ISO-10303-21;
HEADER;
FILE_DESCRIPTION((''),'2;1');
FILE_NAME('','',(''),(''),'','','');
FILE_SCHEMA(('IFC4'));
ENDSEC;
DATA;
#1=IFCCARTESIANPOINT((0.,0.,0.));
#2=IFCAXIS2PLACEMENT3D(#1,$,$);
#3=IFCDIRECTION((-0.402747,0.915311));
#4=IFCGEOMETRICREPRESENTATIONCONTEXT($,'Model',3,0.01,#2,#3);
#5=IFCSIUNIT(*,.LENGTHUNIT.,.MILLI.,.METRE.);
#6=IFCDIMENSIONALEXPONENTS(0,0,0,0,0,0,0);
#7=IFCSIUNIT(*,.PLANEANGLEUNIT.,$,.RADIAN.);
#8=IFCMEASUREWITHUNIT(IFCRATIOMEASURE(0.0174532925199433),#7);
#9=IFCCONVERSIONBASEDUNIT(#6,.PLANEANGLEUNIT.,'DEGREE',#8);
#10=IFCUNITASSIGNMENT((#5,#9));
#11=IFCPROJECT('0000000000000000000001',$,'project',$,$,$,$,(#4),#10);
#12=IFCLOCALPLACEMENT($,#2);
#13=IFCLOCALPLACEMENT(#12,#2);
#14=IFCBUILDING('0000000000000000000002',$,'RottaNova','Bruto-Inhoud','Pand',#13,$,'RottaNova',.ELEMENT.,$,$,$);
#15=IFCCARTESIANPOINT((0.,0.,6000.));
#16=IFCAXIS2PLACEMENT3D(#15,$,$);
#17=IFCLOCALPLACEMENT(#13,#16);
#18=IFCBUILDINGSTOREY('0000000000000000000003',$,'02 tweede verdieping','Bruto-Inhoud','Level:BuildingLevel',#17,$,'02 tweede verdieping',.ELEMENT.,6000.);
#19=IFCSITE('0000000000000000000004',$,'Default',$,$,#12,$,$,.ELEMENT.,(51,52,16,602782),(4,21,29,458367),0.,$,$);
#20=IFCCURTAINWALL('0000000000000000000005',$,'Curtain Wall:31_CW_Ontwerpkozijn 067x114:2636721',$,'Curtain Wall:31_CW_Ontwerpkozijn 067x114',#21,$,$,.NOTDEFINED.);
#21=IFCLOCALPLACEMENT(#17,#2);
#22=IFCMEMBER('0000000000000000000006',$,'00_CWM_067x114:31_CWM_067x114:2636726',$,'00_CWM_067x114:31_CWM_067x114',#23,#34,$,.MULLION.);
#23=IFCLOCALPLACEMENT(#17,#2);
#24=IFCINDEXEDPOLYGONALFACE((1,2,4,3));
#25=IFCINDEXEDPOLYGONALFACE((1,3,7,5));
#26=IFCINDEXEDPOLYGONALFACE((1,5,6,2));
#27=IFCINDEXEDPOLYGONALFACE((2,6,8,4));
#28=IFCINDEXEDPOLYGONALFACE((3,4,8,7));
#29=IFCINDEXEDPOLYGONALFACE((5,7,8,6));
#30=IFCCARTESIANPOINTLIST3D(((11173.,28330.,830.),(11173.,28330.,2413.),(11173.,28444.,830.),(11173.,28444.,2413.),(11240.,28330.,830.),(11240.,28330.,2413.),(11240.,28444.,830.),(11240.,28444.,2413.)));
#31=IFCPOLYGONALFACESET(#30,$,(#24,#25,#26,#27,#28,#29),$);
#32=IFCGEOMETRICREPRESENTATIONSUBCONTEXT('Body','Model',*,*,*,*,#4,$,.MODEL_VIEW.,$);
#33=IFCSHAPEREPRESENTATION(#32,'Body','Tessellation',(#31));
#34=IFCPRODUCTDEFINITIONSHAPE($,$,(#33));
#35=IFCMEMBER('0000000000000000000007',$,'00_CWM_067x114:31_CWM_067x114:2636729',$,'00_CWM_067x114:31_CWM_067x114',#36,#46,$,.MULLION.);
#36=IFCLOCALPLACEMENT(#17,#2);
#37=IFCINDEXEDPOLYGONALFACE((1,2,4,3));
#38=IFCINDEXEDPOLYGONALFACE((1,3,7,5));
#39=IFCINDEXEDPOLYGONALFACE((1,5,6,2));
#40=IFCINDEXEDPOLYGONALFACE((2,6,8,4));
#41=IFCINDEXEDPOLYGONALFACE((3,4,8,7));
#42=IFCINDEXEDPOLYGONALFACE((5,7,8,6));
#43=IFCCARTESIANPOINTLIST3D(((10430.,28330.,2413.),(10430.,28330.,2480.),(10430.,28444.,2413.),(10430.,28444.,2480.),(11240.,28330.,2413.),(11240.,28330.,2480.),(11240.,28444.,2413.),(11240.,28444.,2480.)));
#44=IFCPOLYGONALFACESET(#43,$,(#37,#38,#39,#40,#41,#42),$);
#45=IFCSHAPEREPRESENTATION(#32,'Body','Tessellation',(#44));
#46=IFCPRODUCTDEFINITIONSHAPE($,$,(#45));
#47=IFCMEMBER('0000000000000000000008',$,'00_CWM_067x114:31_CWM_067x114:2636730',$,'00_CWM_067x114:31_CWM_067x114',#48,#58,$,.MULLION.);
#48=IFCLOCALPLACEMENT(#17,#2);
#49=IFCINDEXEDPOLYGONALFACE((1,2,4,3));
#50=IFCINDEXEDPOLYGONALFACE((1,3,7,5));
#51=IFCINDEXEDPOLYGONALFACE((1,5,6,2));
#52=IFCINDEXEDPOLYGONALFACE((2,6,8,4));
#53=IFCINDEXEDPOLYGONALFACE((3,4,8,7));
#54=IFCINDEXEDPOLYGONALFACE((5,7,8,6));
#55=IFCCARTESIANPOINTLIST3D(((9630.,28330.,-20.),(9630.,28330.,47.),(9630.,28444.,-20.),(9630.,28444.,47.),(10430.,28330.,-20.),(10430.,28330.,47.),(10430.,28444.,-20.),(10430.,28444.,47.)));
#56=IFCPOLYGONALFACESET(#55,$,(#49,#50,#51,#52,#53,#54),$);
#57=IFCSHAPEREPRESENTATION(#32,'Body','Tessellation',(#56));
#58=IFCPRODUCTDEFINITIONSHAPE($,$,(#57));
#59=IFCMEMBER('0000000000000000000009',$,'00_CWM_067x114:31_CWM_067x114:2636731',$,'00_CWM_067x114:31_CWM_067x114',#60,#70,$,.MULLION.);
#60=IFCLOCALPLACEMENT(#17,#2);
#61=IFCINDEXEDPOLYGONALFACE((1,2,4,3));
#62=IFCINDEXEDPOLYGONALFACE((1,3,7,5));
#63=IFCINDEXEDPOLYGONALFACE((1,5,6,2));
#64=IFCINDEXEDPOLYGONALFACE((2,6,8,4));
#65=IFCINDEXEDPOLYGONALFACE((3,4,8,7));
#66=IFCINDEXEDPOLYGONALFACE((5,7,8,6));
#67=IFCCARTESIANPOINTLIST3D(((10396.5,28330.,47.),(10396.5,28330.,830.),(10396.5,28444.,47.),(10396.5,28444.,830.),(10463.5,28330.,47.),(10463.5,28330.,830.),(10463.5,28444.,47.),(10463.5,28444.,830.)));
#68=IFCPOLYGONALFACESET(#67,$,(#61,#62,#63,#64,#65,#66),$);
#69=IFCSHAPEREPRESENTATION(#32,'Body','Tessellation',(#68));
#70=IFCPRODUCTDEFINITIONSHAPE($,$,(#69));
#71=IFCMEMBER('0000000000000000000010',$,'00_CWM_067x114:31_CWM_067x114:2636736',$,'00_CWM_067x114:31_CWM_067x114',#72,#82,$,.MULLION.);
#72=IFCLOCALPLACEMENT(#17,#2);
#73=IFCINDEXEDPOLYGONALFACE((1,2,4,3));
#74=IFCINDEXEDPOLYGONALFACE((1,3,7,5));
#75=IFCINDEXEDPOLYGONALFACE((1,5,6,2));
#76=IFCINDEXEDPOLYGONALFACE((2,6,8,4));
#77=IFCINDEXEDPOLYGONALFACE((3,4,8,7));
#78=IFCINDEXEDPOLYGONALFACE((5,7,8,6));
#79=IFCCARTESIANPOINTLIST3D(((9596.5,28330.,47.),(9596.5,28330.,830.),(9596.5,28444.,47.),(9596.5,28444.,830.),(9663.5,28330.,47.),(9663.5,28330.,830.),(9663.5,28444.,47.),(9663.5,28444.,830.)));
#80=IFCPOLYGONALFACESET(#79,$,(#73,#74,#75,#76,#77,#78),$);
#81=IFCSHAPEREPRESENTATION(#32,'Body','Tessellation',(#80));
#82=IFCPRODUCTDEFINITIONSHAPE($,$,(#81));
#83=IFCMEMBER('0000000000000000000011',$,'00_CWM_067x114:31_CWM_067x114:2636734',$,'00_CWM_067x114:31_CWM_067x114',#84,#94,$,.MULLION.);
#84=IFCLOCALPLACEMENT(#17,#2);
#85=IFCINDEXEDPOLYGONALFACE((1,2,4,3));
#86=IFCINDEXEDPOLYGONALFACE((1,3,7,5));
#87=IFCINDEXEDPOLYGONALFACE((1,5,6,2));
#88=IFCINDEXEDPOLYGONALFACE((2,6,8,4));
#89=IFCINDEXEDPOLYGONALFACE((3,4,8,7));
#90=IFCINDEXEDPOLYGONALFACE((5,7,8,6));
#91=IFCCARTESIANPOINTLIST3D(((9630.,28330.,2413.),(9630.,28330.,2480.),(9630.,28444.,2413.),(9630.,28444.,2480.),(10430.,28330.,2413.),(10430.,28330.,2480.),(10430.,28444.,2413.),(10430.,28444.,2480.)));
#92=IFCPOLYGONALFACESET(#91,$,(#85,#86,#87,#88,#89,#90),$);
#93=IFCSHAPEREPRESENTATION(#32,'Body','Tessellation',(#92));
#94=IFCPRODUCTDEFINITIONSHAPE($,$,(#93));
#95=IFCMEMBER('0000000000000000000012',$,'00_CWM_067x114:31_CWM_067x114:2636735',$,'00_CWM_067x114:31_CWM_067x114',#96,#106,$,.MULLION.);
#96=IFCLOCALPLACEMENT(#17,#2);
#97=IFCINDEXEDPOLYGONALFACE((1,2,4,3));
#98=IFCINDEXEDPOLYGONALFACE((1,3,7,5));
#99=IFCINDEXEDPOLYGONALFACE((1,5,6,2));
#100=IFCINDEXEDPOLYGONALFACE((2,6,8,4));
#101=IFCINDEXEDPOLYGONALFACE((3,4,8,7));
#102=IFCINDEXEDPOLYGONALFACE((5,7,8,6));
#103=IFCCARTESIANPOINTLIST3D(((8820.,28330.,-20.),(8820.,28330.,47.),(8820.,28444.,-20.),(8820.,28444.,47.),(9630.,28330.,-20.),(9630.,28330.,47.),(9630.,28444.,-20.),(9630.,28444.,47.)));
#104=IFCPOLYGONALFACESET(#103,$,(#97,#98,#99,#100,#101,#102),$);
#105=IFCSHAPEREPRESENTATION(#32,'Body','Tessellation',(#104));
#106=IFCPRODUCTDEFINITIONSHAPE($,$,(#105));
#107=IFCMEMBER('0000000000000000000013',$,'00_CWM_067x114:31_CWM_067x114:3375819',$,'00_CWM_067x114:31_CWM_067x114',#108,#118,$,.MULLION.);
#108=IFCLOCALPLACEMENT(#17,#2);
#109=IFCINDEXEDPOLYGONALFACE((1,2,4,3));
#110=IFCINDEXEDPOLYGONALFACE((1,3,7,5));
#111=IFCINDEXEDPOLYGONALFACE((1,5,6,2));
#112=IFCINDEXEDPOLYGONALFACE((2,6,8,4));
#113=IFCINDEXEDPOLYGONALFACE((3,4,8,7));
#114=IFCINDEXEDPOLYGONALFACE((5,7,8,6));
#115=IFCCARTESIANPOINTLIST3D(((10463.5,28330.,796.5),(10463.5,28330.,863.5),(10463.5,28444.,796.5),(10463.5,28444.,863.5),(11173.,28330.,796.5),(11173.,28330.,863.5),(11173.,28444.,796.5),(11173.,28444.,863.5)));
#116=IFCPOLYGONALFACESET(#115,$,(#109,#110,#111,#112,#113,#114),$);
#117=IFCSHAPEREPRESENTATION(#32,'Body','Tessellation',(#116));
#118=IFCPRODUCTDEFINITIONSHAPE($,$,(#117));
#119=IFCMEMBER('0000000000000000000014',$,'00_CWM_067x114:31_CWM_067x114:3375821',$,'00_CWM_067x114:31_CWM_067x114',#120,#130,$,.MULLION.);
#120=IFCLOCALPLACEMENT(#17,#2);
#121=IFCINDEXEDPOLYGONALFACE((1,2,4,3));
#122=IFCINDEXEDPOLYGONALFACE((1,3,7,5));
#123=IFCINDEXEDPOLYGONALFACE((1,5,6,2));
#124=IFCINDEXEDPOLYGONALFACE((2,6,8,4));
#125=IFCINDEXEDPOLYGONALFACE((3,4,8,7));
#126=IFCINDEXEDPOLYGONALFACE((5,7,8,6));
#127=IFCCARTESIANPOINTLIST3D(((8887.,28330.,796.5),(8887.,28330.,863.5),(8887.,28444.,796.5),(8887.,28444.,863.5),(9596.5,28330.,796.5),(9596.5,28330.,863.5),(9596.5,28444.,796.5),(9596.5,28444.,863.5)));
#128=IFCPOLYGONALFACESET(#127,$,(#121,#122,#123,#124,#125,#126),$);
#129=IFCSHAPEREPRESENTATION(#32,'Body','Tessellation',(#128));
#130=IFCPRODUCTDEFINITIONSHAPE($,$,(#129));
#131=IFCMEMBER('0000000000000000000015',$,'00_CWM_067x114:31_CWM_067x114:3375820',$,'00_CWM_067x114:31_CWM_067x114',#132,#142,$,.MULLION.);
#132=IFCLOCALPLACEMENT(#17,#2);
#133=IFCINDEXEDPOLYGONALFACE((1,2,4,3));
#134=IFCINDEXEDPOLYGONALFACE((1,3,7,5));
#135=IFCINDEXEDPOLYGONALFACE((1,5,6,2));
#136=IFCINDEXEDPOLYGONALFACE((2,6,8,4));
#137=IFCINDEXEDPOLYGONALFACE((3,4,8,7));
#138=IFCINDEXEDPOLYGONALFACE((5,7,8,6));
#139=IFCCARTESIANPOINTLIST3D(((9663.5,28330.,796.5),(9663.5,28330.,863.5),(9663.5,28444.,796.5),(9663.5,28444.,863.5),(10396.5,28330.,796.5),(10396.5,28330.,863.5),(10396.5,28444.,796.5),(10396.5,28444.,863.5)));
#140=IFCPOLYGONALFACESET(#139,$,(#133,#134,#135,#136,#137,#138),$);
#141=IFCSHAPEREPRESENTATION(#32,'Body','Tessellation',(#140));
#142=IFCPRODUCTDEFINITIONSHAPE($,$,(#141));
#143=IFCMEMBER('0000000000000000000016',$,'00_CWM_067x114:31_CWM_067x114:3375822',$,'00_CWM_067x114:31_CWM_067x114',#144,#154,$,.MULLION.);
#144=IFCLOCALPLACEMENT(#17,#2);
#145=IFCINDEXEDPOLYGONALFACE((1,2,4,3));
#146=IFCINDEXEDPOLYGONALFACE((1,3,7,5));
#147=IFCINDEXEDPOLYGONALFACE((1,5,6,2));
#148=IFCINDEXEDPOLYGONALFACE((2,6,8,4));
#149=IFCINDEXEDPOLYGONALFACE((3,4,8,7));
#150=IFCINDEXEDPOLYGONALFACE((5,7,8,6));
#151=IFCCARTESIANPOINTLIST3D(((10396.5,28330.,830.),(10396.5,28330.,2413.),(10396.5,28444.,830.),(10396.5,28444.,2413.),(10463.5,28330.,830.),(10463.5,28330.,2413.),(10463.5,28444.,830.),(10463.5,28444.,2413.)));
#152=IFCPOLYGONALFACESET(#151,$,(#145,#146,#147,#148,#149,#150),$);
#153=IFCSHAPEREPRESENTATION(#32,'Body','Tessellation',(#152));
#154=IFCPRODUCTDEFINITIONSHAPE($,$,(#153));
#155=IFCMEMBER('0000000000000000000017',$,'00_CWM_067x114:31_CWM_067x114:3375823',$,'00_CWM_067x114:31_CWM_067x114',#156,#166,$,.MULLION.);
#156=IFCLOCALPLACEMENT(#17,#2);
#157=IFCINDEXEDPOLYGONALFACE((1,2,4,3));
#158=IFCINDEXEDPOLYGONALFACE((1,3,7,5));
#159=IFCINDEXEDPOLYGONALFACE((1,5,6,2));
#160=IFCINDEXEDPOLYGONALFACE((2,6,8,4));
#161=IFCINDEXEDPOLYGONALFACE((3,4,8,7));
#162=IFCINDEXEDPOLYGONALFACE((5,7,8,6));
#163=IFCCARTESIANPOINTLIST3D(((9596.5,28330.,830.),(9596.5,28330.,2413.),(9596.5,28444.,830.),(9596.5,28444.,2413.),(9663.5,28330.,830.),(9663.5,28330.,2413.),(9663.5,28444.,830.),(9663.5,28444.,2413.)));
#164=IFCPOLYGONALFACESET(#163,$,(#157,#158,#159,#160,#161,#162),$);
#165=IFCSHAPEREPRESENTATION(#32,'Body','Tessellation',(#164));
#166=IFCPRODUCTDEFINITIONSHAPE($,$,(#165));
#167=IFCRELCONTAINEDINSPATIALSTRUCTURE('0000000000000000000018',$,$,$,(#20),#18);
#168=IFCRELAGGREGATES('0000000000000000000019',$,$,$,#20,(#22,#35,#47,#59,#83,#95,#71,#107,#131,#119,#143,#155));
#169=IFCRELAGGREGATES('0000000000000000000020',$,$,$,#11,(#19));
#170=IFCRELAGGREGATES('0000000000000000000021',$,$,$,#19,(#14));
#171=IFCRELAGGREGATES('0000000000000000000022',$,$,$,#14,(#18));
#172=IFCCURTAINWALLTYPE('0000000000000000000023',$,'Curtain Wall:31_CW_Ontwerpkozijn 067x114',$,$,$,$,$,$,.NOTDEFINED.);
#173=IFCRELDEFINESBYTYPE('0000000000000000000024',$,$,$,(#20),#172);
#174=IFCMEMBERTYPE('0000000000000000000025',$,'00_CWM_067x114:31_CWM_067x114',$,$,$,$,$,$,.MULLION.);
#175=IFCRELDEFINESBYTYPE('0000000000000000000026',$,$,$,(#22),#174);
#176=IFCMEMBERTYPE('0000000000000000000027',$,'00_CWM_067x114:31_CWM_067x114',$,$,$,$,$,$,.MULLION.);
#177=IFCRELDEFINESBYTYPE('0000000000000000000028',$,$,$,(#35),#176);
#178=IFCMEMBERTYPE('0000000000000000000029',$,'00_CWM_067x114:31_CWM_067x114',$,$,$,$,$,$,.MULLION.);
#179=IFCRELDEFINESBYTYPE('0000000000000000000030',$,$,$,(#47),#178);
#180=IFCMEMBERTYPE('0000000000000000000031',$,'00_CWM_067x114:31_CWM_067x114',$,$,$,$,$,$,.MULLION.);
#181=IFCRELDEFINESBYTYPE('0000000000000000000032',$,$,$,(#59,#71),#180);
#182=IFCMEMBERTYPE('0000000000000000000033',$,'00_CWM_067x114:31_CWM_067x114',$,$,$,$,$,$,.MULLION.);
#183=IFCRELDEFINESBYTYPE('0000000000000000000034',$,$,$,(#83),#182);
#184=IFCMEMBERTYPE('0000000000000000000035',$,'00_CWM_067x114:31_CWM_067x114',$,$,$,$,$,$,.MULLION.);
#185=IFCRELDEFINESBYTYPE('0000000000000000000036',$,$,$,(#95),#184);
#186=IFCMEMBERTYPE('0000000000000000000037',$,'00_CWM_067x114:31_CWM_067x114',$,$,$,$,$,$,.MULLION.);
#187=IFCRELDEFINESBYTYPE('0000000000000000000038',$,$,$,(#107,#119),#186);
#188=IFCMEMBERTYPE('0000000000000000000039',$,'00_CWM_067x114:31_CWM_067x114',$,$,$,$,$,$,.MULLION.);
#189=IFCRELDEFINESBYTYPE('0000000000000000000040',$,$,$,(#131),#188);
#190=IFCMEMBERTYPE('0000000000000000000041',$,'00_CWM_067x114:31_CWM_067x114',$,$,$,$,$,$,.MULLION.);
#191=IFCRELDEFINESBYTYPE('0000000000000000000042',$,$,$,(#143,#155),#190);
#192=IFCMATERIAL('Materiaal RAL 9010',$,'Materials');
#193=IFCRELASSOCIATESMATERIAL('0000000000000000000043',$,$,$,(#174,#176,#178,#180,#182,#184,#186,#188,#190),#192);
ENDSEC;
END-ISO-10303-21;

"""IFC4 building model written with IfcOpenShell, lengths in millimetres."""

from ifc_helpers import new_model, entity, si_unit, converted_unit, direction, frame, origin, origin_2d_with_axis, place, context, subcontext, project, spatial, rectangle, extrude, source, transform, mapped, material, material_profile, profile_set, type_object, type_shapes, element, aggregate, save


model = new_model("IFC4")

# Units and contexts
model_context = context("Model", 3, precision=0.01, world=origin(), true_north=direction((-0.402747, 0.915311)))
body_context = subcontext(model_context, "Body", "Model", "MODEL_VIEW")
ifc_project = project(units=[si_unit("LENGTHUNIT", "METRE", prefix="MILLI"), converted_unit("PLANEANGLEUNIT", "DEGREE", entity("IfcRatioMeasure", 0.0174532925199433), si_unit("PLANEANGLEUNIT", "RADIAN"), dimensions=[0, 0, 0, 0, 0, 0, 0])], contexts=[model_context])

# Site, building, storey
site_placement = place(None, origin())
site = spatial("IfcSite", under=ifc_project, at=site_placement, Name="Default", CompositionType="ELEMENT", RefLatitude=(51, 52, 16, 602782), RefLongitude=(4, 21, 29, 458367), RefElevation=0.0)
building_placement = place(site_placement, origin())
building = spatial("IfcBuilding", under=site, at=building_placement, Name="RottaNova", Description="Bruto-Inhoud", ObjectType="Pand", LongName="RottaNova", CompositionType="ELEMENT")
storey_placement = place(building_placement, frame((0.0, 0.0, 6000.0)))
storey = spatial("IfcBuildingStorey", under=building, at=storey_placement, Name="02 tweede verdieping", Description="Bruto-Inhoud", ObjectType="Level:BuildingLevel", LongName="02 tweede verdieping", CompositionType="ELEMENT", Elevation=6000.0)

# Curtain wall, members
curtain_wall_type = type_object("IfcCurtainWallType", Name="Curtain Wall:31_CW_Ontwerpkozijn 067x114", PredefinedType="NOTDEFINED")
curtain_wall_placement = place(storey_placement, frame((0.0, 0.0, -6000.0)))
curtain_wall = element("IfcCurtainWall", 1, at=curtain_wall_placement, inside=storey, type_object=curtain_wall_type, Name="Curtain Wall:31_CW_Ontwerpkozijn 067x114:2636721", ObjectType="Curtain Wall:31_CW_Ontwerpkozijn 067x114", PredefinedType="NOTDEFINED")
ifc_material_1 = material(Name="Materiaal RAL 9010", Category="Materials")
ifc_material_profile = material_profile(ifc_material_1, rectangle(XDim=114.0, YDim=67.0, at=origin_2d_with_axis()), Name="31_CWM_067x114")
ifc_profile_set = profile_set([ifc_material_profile], Name="31_CWM_067x114")
member_type_1 = type_object("IfcMemberType", Name="00_CWM_067x114:31_CWM_067x114", PredefinedType="MULLION", material=ifc_profile_set)
shared_shape_1 = source(origin(), body_context, "Body", "SweptSolid", [
    extrude(rectangle(XDim=114.0, YDim=67.0, at=origin_2d_with_axis()), frame((-33.5, 57.0, -1583.0), z_axis=(0.0, 0.0, 1.0), x_axis=(0.0, -1.0, 0.0)), (0.0, 0.0, 1.0), 1583.0),
])
type_shapes(member_type_1, [shared_shape_1])
member_1_placement = place(curtain_wall_placement, frame((11240.0, 28330.0, 8413.0)))
member_1 = element("IfcMember", 2, at=member_1_placement, type_object=member_type_1, Name="00_CWM_067x114:31_CWM_067x114:2636726", ObjectType="00_CWM_067x114:31_CWM_067x114", PredefinedType="MULLION", context=body_context, shape_type="MappedRepresentation", body=[
    mapped(shared_shape_1, transform((0.0, 0.0, 0.0), scale=1.0)),
])
member_type_2 = type_object("IfcMemberType", Name="00_CWM_067x114:31_CWM_067x114", PredefinedType="MULLION", material=ifc_profile_set)
shared_shape_2 = source(origin(), body_context, "Body", "SweptSolid", [
    extrude(rectangle(XDim=114.0, YDim=67.0, at=origin_2d_with_axis()), frame((-33.5, 57.0, -810.0), z_axis=(0.0, 0.0, 1.0), x_axis=(0.0, -1.0, 0.0)), (0.0, 0.0, 1.0), 810.0),
])
type_shapes(member_type_2, [shared_shape_2])
member_2_placement = place(curtain_wall_placement, frame((10430.0, 28330.0, 8480.0), z_axis=(-1.0, 0.0, 0.0), x_axis=(0.0, 0.0, 1.0)))
member_2 = element("IfcMember", 3, at=member_2_placement, type_object=member_type_2, Name="00_CWM_067x114:31_CWM_067x114:2636729", ObjectType="00_CWM_067x114:31_CWM_067x114", PredefinedType="MULLION", context=body_context, shape_type="MappedRepresentation", body=[
    mapped(shared_shape_2, transform((0.0, 0.0, 0.0), scale=1.0)),
])
member_type_3 = type_object("IfcMemberType", Name="00_CWM_067x114:31_CWM_067x114", PredefinedType="MULLION", material=ifc_profile_set)
shared_shape_3 = source(origin(), body_context, "Body", "SweptSolid", [
    extrude(rectangle(XDim=114.0, YDim=67.0, at=origin_2d_with_axis()), frame((-33.5, 57.0, -800.0), z_axis=(0.0, 0.0, 1.0), x_axis=(0.0, -1.0, 0.0)), (0.0, 0.0, 1.0), 800.0),
])
type_shapes(member_type_3, [shared_shape_3])
member_3_placement = place(curtain_wall_placement, frame((10430.0, 28330.0, 5980.0), z_axis=(1.0, 0.0, 0.0), x_axis=(0.0, 0.0, -1.0)))
member_3 = element("IfcMember", 4, at=member_3_placement, type_object=member_type_3, Name="00_CWM_067x114:31_CWM_067x114:2636730", ObjectType="00_CWM_067x114:31_CWM_067x114", PredefinedType="MULLION", context=body_context, shape_type="MappedRepresentation", body=[
    mapped(shared_shape_3, transform((0.0, 0.0, 0.0), scale=1.0)),
])
member_type_4 = type_object("IfcMemberType", Name="00_CWM_067x114:31_CWM_067x114", PredefinedType="MULLION", material=ifc_profile_set)
shared_shape_4 = source(origin(), body_context, "Body", "SweptSolid", [
    extrude(rectangle(XDim=114.0, YDim=67.0, at=origin_2d_with_axis()), frame((0.0, 57.0, -783.0), z_axis=(0.0, 0.0, 1.0), x_axis=(0.0, -1.0, 0.0)), (0.0, 0.0, 1.0), 783.0),
])
type_shapes(member_type_4, [shared_shape_4])
member_4_placement = place(curtain_wall_placement, frame((10430.0, 28330.0, 6047.0), z_axis=(0.0, 0.0, -1.0), x_axis=(-1.0, 0.0, 0.0)))
member_4 = element("IfcMember", 5, at=member_4_placement, type_object=member_type_4, Name="00_CWM_067x114:31_CWM_067x114:2636731", ObjectType="00_CWM_067x114:31_CWM_067x114", PredefinedType="MULLION", context=body_context, shape_type="MappedRepresentation", body=[
    mapped(shared_shape_4, transform((0.0, 0.0, 0.0), scale=1.0)),
])
member_5_placement = place(curtain_wall_placement, frame((9630.0, 28330.0, 6047.0), z_axis=(0.0, 0.0, -1.0), x_axis=(-1.0, 0.0, 0.0)))
member_5 = element("IfcMember", 6, at=member_5_placement, type_object=member_type_4, Name="00_CWM_067x114:31_CWM_067x114:2636736", ObjectType="00_CWM_067x114:31_CWM_067x114", PredefinedType="MULLION", context=body_context, shape_type="MappedRepresentation", body=[
    mapped(shared_shape_4, transform((0.0, 0.0, 0.0), scale=1.0)),
])
member_type_5 = type_object("IfcMemberType", Name="00_CWM_067x114:31_CWM_067x114", PredefinedType="MULLION", material=ifc_profile_set)
shared_shape_5 = source(origin(), body_context, "Body", "SweptSolid", [
    extrude(rectangle(XDim=114.0, YDim=67.0, at=origin_2d_with_axis()), frame((-33.5, 57.0, -800.0), z_axis=(0.0, 0.0, 1.0), x_axis=(0.0, -1.0, 0.0)), (0.0, 0.0, 1.0), 800.0),
])
type_shapes(member_type_5, [shared_shape_5])
member_6_placement = place(curtain_wall_placement, frame((9630.0, 28330.0, 8480.0), z_axis=(-1.0, 0.0, 0.0), x_axis=(0.0, 0.0, 1.0)))
member_6 = element("IfcMember", 7, at=member_6_placement, type_object=member_type_5, Name="00_CWM_067x114:31_CWM_067x114:2636734", ObjectType="00_CWM_067x114:31_CWM_067x114", PredefinedType="MULLION", context=body_context, shape_type="MappedRepresentation", body=[
    mapped(shared_shape_5, transform((0.0, 0.0, 0.0), scale=1.0)),
])
member_type_6 = type_object("IfcMemberType", Name="00_CWM_067x114:31_CWM_067x114", PredefinedType="MULLION", material=ifc_profile_set)
shared_shape_6 = source(origin(), body_context, "Body", "SweptSolid", [
    extrude(rectangle(XDim=114.0, YDim=67.0, at=origin_2d_with_axis()), frame((-33.5, 57.0, -810.0), z_axis=(0.0, 0.0, 1.0), x_axis=(0.0, -1.0, 0.0)), (0.0, 0.0, 1.0), 810.0),
])
type_shapes(member_type_6, [shared_shape_6])
member_7_placement = place(curtain_wall_placement, frame((9630.0, 28330.0, 5980.0), z_axis=(1.0, 0.0, 0.0), x_axis=(0.0, 0.0, -1.0)))
member_7 = element("IfcMember", 8, at=member_7_placement, type_object=member_type_6, Name="00_CWM_067x114:31_CWM_067x114:2636735", ObjectType="00_CWM_067x114:31_CWM_067x114", PredefinedType="MULLION", context=body_context, shape_type="MappedRepresentation", body=[
    mapped(shared_shape_6, transform((0.0, 0.0, 0.0), scale=1.0)),
])
member_type_7 = type_object("IfcMemberType", Name="00_CWM_067x114:31_CWM_067x114", PredefinedType="MULLION", material=ifc_profile_set)
shared_shape_7 = source(origin(), body_context, "Body", "SweptSolid", [
    extrude(rectangle(XDim=114.0, YDim=67.0, at=origin_2d_with_axis()), frame((0.0, 57.0, -709.5), z_axis=(0.0, 0.0, 1.0), x_axis=(0.0, -1.0, 0.0)), (0.0, 0.0, 1.0), 709.5),
])
type_shapes(member_type_7, [shared_shape_7])
member_8_placement = place(curtain_wall_placement, frame((10463.5, 28330.0, 6830.0), z_axis=(-1.0, 0.0, 0.0), x_axis=(0.0, 0.0, 1.0)))
member_8 = element("IfcMember", 9, at=member_8_placement, type_object=member_type_7, Name="00_CWM_067x114:31_CWM_067x114:3375819", ObjectType="00_CWM_067x114:31_CWM_067x114", PredefinedType="MULLION", context=body_context, shape_type="MappedRepresentation", body=[
    mapped(shared_shape_7, transform((0.0, 0.0, 0.0), scale=1.0)),
])
member_9_placement = place(curtain_wall_placement, frame((8887.0, 28330.0, 6830.0), z_axis=(-1.0, 0.0, 0.0), x_axis=(0.0, 0.0, 1.0)))
member_9 = element("IfcMember", 10, at=member_9_placement, type_object=member_type_7, Name="00_CWM_067x114:31_CWM_067x114:3375821", ObjectType="00_CWM_067x114:31_CWM_067x114", PredefinedType="MULLION", context=body_context, shape_type="MappedRepresentation", body=[
    mapped(shared_shape_7, transform((0.0, 0.0, 0.0), scale=1.0)),
])
member_type_8 = type_object("IfcMemberType", Name="00_CWM_067x114:31_CWM_067x114", PredefinedType="MULLION", material=ifc_profile_set)
shared_shape_8 = source(origin(), body_context, "Body", "SweptSolid", [
    extrude(rectangle(XDim=114.0, YDim=67.0, at=origin_2d_with_axis()), frame((0.0, 57.0, -733.0), z_axis=(0.0, 0.0, 1.0), x_axis=(0.0, -1.0, 0.0)), (0.0, 0.0, 1.0), 733.0),
])
type_shapes(member_type_8, [shared_shape_8])
member_10_placement = place(curtain_wall_placement, frame((9663.5, 28330.0, 6830.0), z_axis=(-1.0, 0.0, 0.0), x_axis=(0.0, 0.0, 1.0)))
member_10 = element("IfcMember", 11, at=member_10_placement, type_object=member_type_8, Name="00_CWM_067x114:31_CWM_067x114:3375820", ObjectType="00_CWM_067x114:31_CWM_067x114", PredefinedType="MULLION", context=body_context, shape_type="MappedRepresentation", body=[
    mapped(shared_shape_8, transform((0.0, 0.0, 0.0), scale=1.0)),
])
member_type_9 = type_object("IfcMemberType", Name="00_CWM_067x114:31_CWM_067x114", PredefinedType="MULLION", material=ifc_profile_set)
shared_shape_9 = source(origin(), body_context, "Body", "SweptSolid", [
    extrude(rectangle(XDim=114.0, YDim=67.0, at=origin_2d_with_axis()), frame((0.0, 57.0, -1583.0), z_axis=(0.0, 0.0, 1.0), x_axis=(0.0, -1.0, 0.0)), (0.0, 0.0, 1.0), 1583.0),
])
type_shapes(member_type_9, [shared_shape_9])
member_11_placement = place(curtain_wall_placement, frame((10430.0, 28330.0, 6830.0), z_axis=(0.0, 0.0, -1.0), x_axis=(-1.0, 0.0, 0.0)))
member_11 = element("IfcMember", 12, at=member_11_placement, type_object=member_type_9, Name="00_CWM_067x114:31_CWM_067x114:3375822", ObjectType="00_CWM_067x114:31_CWM_067x114", PredefinedType="MULLION", context=body_context, shape_type="MappedRepresentation", body=[
    mapped(shared_shape_9, transform((0.0, 0.0, 0.0), scale=1.0)),
])
member_12_placement = place(curtain_wall_placement, frame((9630.0, 28330.0, 6830.0), z_axis=(0.0, 0.0, -1.0), x_axis=(-1.0, 0.0, 0.0)))
member_12 = element("IfcMember", 13, at=member_12_placement, type_object=member_type_9, Name="00_CWM_067x114:31_CWM_067x114:3375823", ObjectType="00_CWM_067x114:31_CWM_067x114", PredefinedType="MULLION", context=body_context, shape_type="MappedRepresentation", body=[
    mapped(shared_shape_9, transform((0.0, 0.0, 0.0), scale=1.0)),
])

aggregate(curtain_wall, [member_1, member_2, member_3, member_4, member_6, member_7, member_5, member_8, member_10, member_9, member_11, member_12])

save(model, "model.ifc")
